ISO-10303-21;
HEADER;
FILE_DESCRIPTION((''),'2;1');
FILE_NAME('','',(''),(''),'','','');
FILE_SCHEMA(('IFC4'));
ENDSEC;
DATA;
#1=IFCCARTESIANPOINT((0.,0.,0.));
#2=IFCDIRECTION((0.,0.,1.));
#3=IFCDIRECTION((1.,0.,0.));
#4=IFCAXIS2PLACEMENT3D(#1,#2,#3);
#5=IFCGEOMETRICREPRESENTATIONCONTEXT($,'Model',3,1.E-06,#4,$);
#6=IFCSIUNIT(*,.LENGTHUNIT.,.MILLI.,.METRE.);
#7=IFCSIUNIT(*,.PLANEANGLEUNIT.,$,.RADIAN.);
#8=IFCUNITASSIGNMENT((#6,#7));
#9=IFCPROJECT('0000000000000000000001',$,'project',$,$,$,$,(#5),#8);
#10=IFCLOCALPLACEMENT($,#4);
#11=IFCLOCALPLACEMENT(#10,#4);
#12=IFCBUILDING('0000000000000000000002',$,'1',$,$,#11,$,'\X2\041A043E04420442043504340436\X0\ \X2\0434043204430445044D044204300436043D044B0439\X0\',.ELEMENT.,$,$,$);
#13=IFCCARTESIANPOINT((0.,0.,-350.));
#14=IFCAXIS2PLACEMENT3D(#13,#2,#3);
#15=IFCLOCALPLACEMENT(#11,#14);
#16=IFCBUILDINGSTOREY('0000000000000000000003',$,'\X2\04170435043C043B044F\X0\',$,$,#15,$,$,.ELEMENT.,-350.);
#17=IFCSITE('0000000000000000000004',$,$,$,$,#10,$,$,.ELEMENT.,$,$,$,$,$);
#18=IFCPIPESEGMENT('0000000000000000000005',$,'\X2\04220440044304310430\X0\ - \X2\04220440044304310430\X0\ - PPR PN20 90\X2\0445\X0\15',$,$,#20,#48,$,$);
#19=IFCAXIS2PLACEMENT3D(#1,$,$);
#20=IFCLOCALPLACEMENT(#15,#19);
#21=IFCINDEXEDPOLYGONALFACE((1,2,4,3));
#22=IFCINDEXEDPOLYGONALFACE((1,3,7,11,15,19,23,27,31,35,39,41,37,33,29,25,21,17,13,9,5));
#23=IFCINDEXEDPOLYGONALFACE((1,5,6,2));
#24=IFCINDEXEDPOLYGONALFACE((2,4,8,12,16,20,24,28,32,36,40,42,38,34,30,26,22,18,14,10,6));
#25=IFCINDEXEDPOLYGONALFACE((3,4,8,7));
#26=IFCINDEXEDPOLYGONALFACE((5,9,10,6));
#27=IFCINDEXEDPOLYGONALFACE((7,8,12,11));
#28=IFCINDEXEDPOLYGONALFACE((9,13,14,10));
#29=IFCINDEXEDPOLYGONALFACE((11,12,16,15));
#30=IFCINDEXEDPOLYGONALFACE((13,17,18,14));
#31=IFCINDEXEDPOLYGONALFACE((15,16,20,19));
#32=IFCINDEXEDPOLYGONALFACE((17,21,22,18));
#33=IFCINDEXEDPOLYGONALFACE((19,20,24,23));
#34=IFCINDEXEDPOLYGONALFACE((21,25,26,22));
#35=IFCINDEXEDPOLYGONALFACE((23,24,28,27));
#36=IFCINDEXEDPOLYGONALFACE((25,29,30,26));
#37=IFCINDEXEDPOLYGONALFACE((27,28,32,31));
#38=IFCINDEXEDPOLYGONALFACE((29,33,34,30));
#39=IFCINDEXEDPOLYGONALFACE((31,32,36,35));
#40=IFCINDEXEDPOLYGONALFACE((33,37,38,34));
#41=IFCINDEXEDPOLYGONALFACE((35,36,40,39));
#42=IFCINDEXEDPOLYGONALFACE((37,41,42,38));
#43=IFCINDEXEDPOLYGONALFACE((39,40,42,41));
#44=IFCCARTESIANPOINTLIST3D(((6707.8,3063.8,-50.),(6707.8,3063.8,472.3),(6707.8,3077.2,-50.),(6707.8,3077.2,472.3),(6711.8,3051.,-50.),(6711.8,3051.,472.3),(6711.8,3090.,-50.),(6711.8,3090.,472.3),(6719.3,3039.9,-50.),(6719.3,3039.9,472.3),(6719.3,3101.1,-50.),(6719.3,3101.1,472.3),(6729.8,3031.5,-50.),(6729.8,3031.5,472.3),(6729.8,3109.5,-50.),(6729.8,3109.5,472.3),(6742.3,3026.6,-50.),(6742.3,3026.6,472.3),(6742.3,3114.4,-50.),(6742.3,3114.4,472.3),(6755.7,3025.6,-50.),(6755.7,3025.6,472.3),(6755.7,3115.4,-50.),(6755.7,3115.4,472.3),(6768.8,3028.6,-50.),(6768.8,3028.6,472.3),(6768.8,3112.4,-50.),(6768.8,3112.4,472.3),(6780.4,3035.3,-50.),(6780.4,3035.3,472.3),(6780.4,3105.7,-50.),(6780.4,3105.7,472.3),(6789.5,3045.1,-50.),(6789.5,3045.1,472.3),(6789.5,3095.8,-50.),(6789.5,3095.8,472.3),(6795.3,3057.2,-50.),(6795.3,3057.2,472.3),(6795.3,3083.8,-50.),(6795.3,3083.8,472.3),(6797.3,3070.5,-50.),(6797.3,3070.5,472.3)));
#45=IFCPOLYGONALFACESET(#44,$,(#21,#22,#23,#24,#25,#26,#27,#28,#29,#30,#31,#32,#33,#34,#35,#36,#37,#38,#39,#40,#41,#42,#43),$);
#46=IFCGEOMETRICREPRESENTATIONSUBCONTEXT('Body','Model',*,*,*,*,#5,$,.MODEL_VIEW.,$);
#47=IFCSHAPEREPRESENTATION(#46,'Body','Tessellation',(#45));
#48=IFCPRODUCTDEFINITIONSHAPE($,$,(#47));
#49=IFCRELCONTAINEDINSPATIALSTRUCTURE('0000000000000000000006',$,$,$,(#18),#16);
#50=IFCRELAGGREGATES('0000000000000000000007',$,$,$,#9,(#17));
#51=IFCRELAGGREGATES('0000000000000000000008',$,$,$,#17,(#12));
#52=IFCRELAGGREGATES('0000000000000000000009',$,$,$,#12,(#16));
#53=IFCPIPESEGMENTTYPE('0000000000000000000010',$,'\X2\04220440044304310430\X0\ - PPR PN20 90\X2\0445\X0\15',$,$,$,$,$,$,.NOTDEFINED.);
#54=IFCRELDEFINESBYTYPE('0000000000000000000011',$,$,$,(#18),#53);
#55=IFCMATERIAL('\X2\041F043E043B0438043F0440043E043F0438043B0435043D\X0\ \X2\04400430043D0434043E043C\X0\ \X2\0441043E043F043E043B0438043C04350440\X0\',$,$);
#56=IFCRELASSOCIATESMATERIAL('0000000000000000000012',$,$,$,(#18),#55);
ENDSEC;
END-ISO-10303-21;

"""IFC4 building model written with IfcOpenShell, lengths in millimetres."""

from ifc_helpers import new_model, entity, si_unit, frame, origin_with_axes, place, context, subcontext, project, spatial, source, transform, mapped, material, type_object, element, save


model = new_model("IFC4")

# Units and contexts
model_context = context("Model", 3, precision=1e-06, world=origin_with_axes())
body_context = subcontext(model_context, "Body", "Model", "MODEL_VIEW")
ifc_project = project(units=[si_unit("LENGTHUNIT", "METRE", prefix="MILLI"), si_unit("PLANEANGLEUNIT", "RADIAN")], contexts=[model_context])

# Site, building, storey
site_placement = place(None, origin_with_axes())
site = spatial("IfcSite", under=ifc_project, at=site_placement, CompositionType="ELEMENT")
building_placement = place(site_placement, origin_with_axes())
building = spatial("IfcBuilding", under=site, at=building_placement, Name="1", LongName="Коттедж двухэтажный", CompositionType="ELEMENT")
storey_placement = place(building_placement, frame((0.0, 0.0, -350.0), z_axis=(0.0, 0.0, 1.0), x_axis=(1.0, 0.0, 0.0)))
storey = spatial("IfcBuildingStorey", under=building, at=storey_placement, Name="Земля", CompositionType="ELEMENT", Elevation=-350.0)

# Pipe segment
ifc_material = material(Name="Полипропилен рандом сополимер")
pipe_segment_type_1 = type_object("IfcPipeSegmentType", Name="Труба - PPR PN20 90х15", PredefinedType="NOTDEFINED")
shared_shape_1 = source(origin_with_axes(), body_context, "Body", "AdvancedSweptSolid", [
    entity("IfcSweptDiskSolid", entity("IfcIndexedPolyCurve", entity("IfcCartesianPointList3D", [[0.0, 0.0, 0.0], [0.0, 0.0, 522.3]]), [entity("IfcLineIndex", [1, 2])]), 45.0),
])
pipe_segment_1_placement = place(storey_placement, frame((6752.3, 3070.5, 472.3), z_axis=(0.0, 0.0, -1.0), x_axis=(1.0, 0.0, 0.0)))
element("IfcPipeSegment", 1, at=pipe_segment_1_placement, inside=storey, type_object=pipe_segment_type_1, material=ifc_material, Name="Труба - Труба - PPR PN20 90х15", context=body_context, shape_type="MappedRepresentation", body=[
    mapped(shared_shape_1, transform((0.0, 0.0, 0.0), x_axis=(1.0, 0.0, 0.0), y_axis=(0.0, 1.0, 0.0), z_axis=(0.0, 0.0, 1.0), scale=1.0)),
])

save(model, "model.ifc")
